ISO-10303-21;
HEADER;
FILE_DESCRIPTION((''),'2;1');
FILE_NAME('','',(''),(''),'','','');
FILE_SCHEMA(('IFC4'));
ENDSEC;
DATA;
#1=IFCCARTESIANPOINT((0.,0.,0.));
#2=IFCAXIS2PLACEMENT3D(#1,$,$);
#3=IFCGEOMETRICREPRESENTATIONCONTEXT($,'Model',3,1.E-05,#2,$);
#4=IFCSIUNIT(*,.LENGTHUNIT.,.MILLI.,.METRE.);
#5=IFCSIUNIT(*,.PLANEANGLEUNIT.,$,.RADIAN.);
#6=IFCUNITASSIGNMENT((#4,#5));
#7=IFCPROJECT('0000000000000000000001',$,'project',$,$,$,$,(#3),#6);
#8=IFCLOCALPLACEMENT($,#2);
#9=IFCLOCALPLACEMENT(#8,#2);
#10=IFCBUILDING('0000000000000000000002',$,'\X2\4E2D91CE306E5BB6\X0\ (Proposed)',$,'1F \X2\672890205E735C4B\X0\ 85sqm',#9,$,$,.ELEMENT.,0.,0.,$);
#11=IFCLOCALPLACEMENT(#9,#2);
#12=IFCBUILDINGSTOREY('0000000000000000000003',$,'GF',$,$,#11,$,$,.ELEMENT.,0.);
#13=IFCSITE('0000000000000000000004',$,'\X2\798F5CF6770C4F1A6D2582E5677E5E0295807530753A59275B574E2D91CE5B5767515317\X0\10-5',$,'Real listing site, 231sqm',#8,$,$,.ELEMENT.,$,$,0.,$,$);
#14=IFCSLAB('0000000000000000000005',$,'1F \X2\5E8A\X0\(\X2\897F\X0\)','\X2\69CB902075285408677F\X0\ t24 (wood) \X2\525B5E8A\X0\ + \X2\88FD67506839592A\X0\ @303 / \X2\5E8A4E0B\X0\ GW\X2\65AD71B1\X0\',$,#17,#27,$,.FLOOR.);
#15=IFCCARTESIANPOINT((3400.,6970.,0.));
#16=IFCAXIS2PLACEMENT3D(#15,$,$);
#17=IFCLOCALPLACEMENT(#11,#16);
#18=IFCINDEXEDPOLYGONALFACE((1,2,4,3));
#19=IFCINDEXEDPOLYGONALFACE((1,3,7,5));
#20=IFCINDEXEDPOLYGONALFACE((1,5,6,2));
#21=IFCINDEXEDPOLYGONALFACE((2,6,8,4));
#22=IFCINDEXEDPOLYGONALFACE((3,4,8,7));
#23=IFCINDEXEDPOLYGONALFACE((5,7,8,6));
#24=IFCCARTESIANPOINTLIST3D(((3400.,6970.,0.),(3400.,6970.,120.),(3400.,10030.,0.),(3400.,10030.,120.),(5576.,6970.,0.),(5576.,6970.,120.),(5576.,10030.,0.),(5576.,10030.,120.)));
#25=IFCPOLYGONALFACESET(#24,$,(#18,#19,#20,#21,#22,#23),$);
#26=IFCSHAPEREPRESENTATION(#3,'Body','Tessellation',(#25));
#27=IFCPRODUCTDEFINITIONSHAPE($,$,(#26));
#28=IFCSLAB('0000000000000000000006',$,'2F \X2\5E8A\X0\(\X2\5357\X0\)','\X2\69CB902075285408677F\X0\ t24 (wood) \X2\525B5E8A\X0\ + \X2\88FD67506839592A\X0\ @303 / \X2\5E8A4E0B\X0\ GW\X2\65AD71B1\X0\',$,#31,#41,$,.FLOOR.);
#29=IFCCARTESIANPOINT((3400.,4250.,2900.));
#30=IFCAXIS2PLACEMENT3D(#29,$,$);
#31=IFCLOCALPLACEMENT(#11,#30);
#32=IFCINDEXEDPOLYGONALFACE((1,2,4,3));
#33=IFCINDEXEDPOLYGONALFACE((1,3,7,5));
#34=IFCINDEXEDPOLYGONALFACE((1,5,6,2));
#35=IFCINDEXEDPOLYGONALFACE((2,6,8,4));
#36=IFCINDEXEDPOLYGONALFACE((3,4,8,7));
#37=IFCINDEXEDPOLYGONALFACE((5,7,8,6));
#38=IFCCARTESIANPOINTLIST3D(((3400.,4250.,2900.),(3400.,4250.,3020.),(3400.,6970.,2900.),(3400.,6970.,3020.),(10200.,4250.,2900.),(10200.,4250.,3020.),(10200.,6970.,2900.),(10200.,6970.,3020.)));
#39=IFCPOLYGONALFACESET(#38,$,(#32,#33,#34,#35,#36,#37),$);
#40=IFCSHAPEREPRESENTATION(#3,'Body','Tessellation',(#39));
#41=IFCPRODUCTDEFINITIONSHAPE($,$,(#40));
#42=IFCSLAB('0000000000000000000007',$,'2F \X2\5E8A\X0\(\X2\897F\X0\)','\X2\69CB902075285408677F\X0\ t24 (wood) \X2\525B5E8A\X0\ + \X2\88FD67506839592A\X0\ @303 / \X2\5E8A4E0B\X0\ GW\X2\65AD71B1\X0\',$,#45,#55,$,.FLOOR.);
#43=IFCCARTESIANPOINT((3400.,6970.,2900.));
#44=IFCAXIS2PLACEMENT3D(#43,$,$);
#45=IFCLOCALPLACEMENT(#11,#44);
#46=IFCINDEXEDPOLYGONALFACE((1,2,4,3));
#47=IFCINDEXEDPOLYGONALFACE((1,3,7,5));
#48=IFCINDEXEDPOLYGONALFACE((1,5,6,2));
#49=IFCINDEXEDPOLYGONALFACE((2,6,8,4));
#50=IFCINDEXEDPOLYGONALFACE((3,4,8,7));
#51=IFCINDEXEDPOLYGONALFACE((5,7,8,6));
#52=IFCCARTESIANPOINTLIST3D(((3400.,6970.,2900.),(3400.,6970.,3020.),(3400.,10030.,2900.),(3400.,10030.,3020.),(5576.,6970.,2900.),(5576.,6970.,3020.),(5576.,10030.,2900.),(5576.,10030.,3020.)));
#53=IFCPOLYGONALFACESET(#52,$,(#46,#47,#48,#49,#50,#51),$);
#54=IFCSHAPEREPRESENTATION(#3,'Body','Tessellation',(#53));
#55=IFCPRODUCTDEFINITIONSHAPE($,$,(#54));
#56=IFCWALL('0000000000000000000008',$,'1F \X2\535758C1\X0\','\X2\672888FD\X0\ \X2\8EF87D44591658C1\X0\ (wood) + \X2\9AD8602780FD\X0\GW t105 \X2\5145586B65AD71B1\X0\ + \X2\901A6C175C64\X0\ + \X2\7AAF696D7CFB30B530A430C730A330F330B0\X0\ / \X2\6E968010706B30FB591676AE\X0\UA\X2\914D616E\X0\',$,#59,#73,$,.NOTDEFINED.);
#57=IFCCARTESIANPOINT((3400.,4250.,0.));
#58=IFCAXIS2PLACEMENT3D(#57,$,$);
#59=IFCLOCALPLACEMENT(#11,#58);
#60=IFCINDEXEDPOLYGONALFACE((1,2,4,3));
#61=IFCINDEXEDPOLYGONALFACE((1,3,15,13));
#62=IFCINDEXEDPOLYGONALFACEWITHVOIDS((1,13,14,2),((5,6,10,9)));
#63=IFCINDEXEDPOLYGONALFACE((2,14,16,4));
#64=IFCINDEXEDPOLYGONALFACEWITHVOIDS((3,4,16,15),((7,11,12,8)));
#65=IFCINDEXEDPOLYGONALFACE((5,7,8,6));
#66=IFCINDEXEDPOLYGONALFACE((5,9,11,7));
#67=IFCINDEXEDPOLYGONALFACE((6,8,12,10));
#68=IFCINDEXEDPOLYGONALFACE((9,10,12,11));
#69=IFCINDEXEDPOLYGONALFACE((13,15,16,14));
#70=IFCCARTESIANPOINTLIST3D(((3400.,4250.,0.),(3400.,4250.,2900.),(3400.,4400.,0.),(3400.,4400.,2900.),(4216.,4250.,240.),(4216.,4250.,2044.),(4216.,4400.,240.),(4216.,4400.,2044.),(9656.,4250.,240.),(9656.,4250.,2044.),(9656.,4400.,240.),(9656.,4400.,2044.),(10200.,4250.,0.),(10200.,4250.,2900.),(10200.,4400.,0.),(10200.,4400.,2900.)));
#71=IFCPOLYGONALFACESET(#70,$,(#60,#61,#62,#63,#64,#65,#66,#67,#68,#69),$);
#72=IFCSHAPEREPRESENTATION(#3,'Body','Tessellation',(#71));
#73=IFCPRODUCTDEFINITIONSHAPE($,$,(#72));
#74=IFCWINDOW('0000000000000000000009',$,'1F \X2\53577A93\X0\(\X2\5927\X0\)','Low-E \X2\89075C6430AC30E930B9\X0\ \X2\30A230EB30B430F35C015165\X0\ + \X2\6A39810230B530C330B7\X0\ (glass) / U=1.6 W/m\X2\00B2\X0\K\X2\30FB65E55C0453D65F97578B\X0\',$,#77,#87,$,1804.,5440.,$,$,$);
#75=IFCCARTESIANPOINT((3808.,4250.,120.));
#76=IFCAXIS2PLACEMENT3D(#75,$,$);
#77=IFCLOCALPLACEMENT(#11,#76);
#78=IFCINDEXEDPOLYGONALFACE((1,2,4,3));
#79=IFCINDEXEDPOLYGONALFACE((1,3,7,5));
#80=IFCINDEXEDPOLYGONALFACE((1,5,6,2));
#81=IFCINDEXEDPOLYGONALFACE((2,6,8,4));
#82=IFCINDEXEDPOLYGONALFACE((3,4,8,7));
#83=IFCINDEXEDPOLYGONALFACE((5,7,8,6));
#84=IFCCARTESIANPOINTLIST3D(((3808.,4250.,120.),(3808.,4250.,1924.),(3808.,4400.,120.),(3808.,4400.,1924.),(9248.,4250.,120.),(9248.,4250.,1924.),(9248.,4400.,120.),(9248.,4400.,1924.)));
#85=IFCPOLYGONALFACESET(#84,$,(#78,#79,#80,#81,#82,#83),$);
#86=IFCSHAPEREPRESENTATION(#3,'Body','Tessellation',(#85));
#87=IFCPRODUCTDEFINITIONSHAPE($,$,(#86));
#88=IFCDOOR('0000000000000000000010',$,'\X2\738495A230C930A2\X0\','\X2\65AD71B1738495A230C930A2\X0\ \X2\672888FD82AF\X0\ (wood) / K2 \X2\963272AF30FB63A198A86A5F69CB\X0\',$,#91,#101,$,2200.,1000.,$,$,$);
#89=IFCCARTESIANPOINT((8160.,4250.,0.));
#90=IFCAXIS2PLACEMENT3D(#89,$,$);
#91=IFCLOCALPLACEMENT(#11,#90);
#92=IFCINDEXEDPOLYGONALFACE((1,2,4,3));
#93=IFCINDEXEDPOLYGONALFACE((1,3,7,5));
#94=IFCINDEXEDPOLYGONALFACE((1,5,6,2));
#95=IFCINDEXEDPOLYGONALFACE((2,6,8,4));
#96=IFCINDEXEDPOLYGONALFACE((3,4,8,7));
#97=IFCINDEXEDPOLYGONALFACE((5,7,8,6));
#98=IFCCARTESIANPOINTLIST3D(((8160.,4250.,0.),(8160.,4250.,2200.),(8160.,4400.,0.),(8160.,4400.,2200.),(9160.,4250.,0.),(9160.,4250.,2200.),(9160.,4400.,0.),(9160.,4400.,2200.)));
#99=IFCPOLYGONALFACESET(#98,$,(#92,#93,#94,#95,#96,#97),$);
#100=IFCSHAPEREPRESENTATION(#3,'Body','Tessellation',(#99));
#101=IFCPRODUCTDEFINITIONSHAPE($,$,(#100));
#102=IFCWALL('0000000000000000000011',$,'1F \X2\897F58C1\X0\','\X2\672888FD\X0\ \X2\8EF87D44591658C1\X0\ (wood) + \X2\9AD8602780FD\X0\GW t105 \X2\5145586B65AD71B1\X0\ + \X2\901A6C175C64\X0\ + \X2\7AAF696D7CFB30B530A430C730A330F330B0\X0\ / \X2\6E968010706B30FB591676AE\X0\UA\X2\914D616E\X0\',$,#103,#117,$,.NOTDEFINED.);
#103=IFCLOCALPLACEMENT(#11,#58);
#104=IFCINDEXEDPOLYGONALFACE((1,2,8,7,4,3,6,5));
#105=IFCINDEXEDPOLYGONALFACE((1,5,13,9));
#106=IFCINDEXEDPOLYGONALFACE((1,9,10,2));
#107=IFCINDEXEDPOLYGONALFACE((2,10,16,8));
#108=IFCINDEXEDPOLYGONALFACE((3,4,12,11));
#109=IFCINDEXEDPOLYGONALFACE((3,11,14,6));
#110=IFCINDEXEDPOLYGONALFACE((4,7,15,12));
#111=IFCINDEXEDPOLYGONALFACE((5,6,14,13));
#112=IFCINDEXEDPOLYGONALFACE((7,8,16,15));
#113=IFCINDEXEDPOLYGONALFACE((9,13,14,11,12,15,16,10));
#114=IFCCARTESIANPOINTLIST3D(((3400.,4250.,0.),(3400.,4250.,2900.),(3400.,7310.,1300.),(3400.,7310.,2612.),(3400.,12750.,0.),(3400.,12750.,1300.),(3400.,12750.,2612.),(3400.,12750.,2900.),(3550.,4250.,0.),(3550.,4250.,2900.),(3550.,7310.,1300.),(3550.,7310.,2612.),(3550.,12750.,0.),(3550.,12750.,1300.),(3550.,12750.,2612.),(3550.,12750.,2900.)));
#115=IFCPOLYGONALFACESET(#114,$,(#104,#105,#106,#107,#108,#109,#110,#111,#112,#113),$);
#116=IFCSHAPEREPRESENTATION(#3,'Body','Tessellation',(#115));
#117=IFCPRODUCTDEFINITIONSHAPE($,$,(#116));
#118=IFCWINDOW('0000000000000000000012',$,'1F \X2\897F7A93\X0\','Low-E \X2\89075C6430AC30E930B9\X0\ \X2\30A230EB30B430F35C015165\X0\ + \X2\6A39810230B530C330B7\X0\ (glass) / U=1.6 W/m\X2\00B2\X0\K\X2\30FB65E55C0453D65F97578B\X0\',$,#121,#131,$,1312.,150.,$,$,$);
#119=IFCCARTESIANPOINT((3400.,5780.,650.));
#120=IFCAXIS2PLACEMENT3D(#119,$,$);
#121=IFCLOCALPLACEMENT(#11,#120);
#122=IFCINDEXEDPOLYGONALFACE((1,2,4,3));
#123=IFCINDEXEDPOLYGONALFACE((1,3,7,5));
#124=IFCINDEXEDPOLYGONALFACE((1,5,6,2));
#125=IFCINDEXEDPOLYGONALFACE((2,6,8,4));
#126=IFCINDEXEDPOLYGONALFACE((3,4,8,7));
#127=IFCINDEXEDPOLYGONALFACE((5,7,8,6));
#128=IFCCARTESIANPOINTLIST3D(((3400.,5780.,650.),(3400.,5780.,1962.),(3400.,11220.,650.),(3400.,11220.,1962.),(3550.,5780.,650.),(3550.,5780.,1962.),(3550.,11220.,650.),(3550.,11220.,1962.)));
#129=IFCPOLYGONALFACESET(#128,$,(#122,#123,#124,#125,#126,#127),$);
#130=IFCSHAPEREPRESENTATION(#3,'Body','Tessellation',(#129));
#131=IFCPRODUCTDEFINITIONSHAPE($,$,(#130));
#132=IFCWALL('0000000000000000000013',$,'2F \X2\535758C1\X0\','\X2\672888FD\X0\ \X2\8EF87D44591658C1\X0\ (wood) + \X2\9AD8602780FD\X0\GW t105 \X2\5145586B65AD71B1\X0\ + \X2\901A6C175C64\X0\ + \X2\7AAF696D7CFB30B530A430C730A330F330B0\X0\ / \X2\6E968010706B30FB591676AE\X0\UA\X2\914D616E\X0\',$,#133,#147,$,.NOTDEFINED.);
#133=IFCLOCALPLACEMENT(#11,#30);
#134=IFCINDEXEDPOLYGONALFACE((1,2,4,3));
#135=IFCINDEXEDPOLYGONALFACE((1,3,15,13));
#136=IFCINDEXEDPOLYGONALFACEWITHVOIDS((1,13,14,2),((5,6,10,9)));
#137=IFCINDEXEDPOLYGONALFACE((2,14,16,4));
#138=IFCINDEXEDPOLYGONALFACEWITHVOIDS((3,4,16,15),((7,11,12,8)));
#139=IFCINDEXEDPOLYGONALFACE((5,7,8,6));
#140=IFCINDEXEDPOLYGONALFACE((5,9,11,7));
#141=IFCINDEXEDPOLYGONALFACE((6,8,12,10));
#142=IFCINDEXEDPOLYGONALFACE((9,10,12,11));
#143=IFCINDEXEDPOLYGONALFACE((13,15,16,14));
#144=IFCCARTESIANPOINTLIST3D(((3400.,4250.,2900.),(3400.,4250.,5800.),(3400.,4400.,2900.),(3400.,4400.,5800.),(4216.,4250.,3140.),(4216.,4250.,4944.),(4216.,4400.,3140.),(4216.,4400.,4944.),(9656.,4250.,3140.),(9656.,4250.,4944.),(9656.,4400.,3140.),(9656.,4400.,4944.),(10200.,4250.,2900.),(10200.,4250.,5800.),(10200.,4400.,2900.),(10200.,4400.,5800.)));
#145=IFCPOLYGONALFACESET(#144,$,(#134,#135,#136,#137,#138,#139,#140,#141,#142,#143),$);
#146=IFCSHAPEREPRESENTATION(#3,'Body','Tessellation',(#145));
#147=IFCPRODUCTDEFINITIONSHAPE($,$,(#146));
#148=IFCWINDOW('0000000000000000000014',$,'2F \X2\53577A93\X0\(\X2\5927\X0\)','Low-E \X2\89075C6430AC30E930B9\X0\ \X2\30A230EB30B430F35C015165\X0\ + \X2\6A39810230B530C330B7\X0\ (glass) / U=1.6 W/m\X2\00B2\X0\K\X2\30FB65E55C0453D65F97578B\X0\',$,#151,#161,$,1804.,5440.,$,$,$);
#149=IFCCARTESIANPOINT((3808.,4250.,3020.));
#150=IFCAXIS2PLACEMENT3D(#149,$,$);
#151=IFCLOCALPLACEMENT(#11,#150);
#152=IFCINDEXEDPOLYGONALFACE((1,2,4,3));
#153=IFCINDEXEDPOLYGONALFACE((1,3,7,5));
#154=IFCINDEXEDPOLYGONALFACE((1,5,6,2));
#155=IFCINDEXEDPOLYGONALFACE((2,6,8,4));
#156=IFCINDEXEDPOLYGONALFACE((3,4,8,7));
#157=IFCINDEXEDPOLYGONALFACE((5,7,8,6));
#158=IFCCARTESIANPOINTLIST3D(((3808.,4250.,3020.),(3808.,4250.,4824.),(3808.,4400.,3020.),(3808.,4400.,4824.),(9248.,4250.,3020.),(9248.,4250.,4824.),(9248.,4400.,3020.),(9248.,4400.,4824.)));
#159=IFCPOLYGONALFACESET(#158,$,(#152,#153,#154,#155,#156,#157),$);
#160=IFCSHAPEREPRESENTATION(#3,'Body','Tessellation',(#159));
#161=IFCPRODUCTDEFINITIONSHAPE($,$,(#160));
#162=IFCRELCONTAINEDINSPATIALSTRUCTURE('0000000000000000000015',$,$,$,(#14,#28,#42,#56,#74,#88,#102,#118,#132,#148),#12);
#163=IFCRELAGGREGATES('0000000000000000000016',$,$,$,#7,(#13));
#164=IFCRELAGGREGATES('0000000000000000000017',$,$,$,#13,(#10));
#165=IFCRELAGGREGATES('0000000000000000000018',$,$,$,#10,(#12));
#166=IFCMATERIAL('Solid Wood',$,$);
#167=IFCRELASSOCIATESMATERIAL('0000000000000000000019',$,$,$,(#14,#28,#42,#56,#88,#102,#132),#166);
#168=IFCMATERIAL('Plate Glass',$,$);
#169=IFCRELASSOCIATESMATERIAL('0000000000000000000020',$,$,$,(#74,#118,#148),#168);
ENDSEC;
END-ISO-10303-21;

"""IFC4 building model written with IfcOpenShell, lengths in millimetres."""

from ifc_helpers import new_model, si_unit, frame, frame_2d, origin, place, context, project, spatial, rectangle, extrude, material, element, fill, save


model = new_model("IFC4")

# Units and contexts
model_context = context("Model", 3, precision=1e-05, world=origin())
ifc_project = project(units=[si_unit("LENGTHUNIT", "METRE", prefix="MILLI"), si_unit("PLANEANGLEUNIT", "RADIAN")], contexts=[model_context])

# Site, building, storey
site_placement = place(None, origin())
site = spatial("IfcSite", under=ifc_project, at=site_placement, Name="福島県会津若松市門田町大字中野字村北10-5", ObjectType="Real listing site, 231sqm", CompositionType="ELEMENT", RefElevation=0.0)
building_placement = place(site_placement, origin())
building = spatial("IfcBuilding", under=site, at=building_placement, Name="中野の家 (Proposed)", ObjectType="1F 木造平屋 85sqm", CompositionType="ELEMENT", ElevationOfRefHeight=0.0, ElevationOfTerrain=0.0)
storey_placement = place(building_placement, origin())
storey = spatial("IfcBuildingStorey", under=building, at=storey_placement, Name="GF", CompositionType="ELEMENT", Elevation=0.0)

# Slabs
ifc_material_1 = material(Name="Solid Wood")
slab_1_placement = place(storey_placement, frame((3400.0, 6970.0, 0.0)))
element("IfcSlab", 1, at=slab_1_placement, inside=storey, material=ifc_material_1, Name="1F 床(西)", Description="構造用合板 t24 (wood) 剛床 + 製材根太 @303 / 床下 GW断熱", PredefinedType="FLOOR", context=model_context, shape_type="SweptSolid", body=[
    extrude(rectangle(XDim=2176.0, YDim=3060.0, at=frame_2d((1088.0, 1530.0))), frame((3400.0, 6970.0, 0.0)), (0.0, 0.0, 1.0), 120.0),
])
slab_2_placement = place(storey_placement, frame((3400.0, 4250.0, 2900.0)))
element("IfcSlab", 2, at=slab_2_placement, inside=storey, material=ifc_material_1, Name="2F 床(南)", Description="構造用合板 t24 (wood) 剛床 + 製材根太 @303 / 床下 GW断熱", PredefinedType="FLOOR", context=model_context, shape_type="SweptSolid", body=[
    extrude(rectangle(XDim=6800.0, YDim=2720.0, at=frame_2d((3400.0, 1360.0))), frame((3400.0, 4250.0, 2900.0)), (0.0, 0.0, 1.0), 120.0),
])
slab_3_placement = place(storey_placement, frame((3400.0, 6970.0, 2900.0)))
element("IfcSlab", 3, at=slab_3_placement, inside=storey, material=ifc_material_1, Name="2F 床(西)", Description="構造用合板 t24 (wood) 剛床 + 製材根太 @303 / 床下 GW断熱", PredefinedType="FLOOR", context=model_context, shape_type="SweptSolid", body=[
    extrude(rectangle(XDim=2176.0, YDim=3060.0, at=frame_2d((1088.0, 1530.0))), frame((3400.0, 6970.0, 2900.0)), (0.0, 0.0, 1.0), 120.0),
])

# Wall, openings, window, door
wall_1_placement = place(storey_placement, frame((3400.0, 4250.0, 0.0)))
wall_1 = element("IfcWall", 4, at=wall_1_placement, inside=storey, material=ifc_material_1, Name="1F 南壁", Description="木製 軸組外壁 (wood) + 高性能GW t105 充填断熱 + 通気層 + 窯業系サイディング / 準耐火・外皮UA配慮", PredefinedType="NOTDEFINED", context=model_context, shape_type="SweptSolid", body=[
    extrude(rectangle(XDim=6800.0, YDim=150.0, at=frame_2d((3400.0, 75.0))), frame((3400.0, 4250.0, 0.0)), (0.0, 0.0, 1.0), 2900.0),
])
opening_1_placement = place(storey_placement, frame((3808.0, 4250.0, 120.0)))
opening_1 = element("IfcOpeningElement", 5, at=opening_1_placement, cuts=wall_1, PredefinedType="NOTDEFINED", context=model_context, shape_type="SweptSolid", body=[
    extrude(rectangle(XDim=5440.0, YDim=150.0, at=frame_2d((2720.0, 75.0))), frame((3808.0, 4250.0, 120.0)), (0.0, 0.0, 1.0), 1804.0),
])
opening_2_placement = place(storey_placement, frame((8160.0, 4250.0, 0.0)))
opening_2 = element("IfcOpeningElement", 6, at=opening_2_placement, cuts=wall_1, PredefinedType="NOTDEFINED", context=model_context, shape_type="SweptSolid", body=[
    extrude(rectangle(XDim=1000.0, YDim=150.0, at=frame_2d((500.0, 75.0))), frame((8160.0, 4250.0, 0.0)), (0.0, 0.0, 1.0), 2200.0),
])
ifc_material_2 = material(Name="Plate Glass")
window_1_placement = place(storey_placement, frame((3808.0, 4250.0, 120.0)))
window_1 = element("IfcWindow", 7, at=window_1_placement, inside=storey, material=ifc_material_2, Name="1F 南窓(大)", Description="Low-E 複層ガラス アルゴン封入 + 樹脂サッシ (glass) / U=1.6 W/m²K・日射取得型", OverallHeight=1804.0, OverallWidth=5440.0, context=model_context, shape_type="SweptSolid", body=[
    extrude(rectangle(XDim=5440.0, YDim=150.0, at=frame_2d((2720.0, 75.0))), frame((3808.0, 4250.0, 120.0)), (0.0, 0.0, 1.0), 1804.0),
])
fill(opening_1, window_1)
door_placement = place(storey_placement, frame((8160.0, 4250.0, 0.0)))
door = element("IfcDoor", 8, at=door_placement, inside=storey, material=ifc_material_1, Name="玄関ドア", Description="断熱玄関ドア 木製芯 (wood) / K2 防犯・採風機構", OverallHeight=2200.0, OverallWidth=1000.0, context=model_context, shape_type="SweptSolid", body=[
    extrude(rectangle(XDim=1000.0, YDim=150.0, at=frame_2d((500.0, 75.0))), frame((8160.0, 4250.0, 0.0)), (0.0, 0.0, 1.0), 2200.0),
])
fill(opening_2, door)

# Walls, openings, windows
wall_2_placement = place(storey_placement, frame((3400.0, 4250.0, 0.0)))
wall_2 = element("IfcWall", 9, at=wall_2_placement, inside=storey, material=ifc_material_1, Name="1F 西壁", Description="木製 軸組外壁 (wood) + 高性能GW t105 充填断熱 + 通気層 + 窯業系サイディング / 準耐火・外皮UA配慮", PredefinedType="NOTDEFINED", context=model_context, shape_type="SweptSolid", body=[
    extrude(rectangle(XDim=150.0, YDim=8500.0, at=frame_2d((75.0, 4250.0))), frame((3400.0, 4250.0, 0.0)), (0.0, 0.0, 1.0), 2900.0),
])
opening_3_placement = place(storey_placement, frame((3400.0, 5780.0, 650.0)))
opening_3 = element("IfcOpeningElement", 10, at=opening_3_placement, cuts=wall_2, PredefinedType="NOTDEFINED", context=model_context, shape_type="SweptSolid", body=[
    extrude(rectangle(XDim=150.0, YDim=5440.0, at=frame_2d((75.0, 2720.0))), frame((3400.0, 5780.0, 650.0)), (0.0, 0.0, 1.0), 1312.0),
])
window_2_placement = place(storey_placement, frame((3400.0, 5780.0, 650.0)))
window_2 = element("IfcWindow", 11, at=window_2_placement, inside=storey, material=ifc_material_2, Name="1F 西窓", Description="Low-E 複層ガラス アルゴン封入 + 樹脂サッシ (glass) / U=1.6 W/m²K・日射取得型", OverallHeight=1312.0, OverallWidth=150.0, context=model_context, shape_type="SweptSolid", body=[
    extrude(rectangle(XDim=150.0, YDim=5440.0, at=frame_2d((75.0, 2720.0))), frame((3400.0, 5780.0, 650.0)), (0.0, 0.0, 1.0), 1312.0),
])
fill(opening_3, window_2)
wall_3_placement = place(storey_placement, frame((3400.0, 4250.0, 2900.0)))
wall_3 = element("IfcWall", 12, at=wall_3_placement, inside=storey, material=ifc_material_1, Name="2F 南壁", Description="木製 軸組外壁 (wood) + 高性能GW t105 充填断熱 + 通気層 + 窯業系サイディング / 準耐火・外皮UA配慮", PredefinedType="NOTDEFINED", context=model_context, shape_type="SweptSolid", body=[
    extrude(rectangle(XDim=6800.0, YDim=150.0, at=frame_2d((3400.0, 75.0))), frame((3400.0, 4250.0, 2900.0)), (0.0, 0.0, 1.0), 2900.0),
])
opening_4_placement = place(storey_placement, frame((3808.0, 4250.0, 3020.0)))
opening_4 = element("IfcOpeningElement", 13, at=opening_4_placement, cuts=wall_3, PredefinedType="NOTDEFINED", context=model_context, shape_type="SweptSolid", body=[
    extrude(rectangle(XDim=5440.0, YDim=150.0, at=frame_2d((2720.0, 75.0))), frame((3808.0, 4250.0, 3020.0)), (0.0, 0.0, 1.0), 1804.0),
])
window_3_placement = place(storey_placement, frame((3808.0, 4250.0, 3020.0)))
window_3 = element("IfcWindow", 14, at=window_3_placement, inside=storey, material=ifc_material_2, Name="2F 南窓(大)", Description="Low-E 複層ガラス アルゴン封入 + 樹脂サッシ (glass) / U=1.6 W/m²K・日射取得型", OverallHeight=1804.0, OverallWidth=5440.0, context=model_context, shape_type="SweptSolid", body=[
    extrude(rectangle(XDim=5440.0, YDim=150.0, at=frame_2d((2720.0, 75.0))), frame((3808.0, 4250.0, 3020.0)), (0.0, 0.0, 1.0), 1804.0),
])
fill(opening_4, window_3)

save(model, "model.ifc")
